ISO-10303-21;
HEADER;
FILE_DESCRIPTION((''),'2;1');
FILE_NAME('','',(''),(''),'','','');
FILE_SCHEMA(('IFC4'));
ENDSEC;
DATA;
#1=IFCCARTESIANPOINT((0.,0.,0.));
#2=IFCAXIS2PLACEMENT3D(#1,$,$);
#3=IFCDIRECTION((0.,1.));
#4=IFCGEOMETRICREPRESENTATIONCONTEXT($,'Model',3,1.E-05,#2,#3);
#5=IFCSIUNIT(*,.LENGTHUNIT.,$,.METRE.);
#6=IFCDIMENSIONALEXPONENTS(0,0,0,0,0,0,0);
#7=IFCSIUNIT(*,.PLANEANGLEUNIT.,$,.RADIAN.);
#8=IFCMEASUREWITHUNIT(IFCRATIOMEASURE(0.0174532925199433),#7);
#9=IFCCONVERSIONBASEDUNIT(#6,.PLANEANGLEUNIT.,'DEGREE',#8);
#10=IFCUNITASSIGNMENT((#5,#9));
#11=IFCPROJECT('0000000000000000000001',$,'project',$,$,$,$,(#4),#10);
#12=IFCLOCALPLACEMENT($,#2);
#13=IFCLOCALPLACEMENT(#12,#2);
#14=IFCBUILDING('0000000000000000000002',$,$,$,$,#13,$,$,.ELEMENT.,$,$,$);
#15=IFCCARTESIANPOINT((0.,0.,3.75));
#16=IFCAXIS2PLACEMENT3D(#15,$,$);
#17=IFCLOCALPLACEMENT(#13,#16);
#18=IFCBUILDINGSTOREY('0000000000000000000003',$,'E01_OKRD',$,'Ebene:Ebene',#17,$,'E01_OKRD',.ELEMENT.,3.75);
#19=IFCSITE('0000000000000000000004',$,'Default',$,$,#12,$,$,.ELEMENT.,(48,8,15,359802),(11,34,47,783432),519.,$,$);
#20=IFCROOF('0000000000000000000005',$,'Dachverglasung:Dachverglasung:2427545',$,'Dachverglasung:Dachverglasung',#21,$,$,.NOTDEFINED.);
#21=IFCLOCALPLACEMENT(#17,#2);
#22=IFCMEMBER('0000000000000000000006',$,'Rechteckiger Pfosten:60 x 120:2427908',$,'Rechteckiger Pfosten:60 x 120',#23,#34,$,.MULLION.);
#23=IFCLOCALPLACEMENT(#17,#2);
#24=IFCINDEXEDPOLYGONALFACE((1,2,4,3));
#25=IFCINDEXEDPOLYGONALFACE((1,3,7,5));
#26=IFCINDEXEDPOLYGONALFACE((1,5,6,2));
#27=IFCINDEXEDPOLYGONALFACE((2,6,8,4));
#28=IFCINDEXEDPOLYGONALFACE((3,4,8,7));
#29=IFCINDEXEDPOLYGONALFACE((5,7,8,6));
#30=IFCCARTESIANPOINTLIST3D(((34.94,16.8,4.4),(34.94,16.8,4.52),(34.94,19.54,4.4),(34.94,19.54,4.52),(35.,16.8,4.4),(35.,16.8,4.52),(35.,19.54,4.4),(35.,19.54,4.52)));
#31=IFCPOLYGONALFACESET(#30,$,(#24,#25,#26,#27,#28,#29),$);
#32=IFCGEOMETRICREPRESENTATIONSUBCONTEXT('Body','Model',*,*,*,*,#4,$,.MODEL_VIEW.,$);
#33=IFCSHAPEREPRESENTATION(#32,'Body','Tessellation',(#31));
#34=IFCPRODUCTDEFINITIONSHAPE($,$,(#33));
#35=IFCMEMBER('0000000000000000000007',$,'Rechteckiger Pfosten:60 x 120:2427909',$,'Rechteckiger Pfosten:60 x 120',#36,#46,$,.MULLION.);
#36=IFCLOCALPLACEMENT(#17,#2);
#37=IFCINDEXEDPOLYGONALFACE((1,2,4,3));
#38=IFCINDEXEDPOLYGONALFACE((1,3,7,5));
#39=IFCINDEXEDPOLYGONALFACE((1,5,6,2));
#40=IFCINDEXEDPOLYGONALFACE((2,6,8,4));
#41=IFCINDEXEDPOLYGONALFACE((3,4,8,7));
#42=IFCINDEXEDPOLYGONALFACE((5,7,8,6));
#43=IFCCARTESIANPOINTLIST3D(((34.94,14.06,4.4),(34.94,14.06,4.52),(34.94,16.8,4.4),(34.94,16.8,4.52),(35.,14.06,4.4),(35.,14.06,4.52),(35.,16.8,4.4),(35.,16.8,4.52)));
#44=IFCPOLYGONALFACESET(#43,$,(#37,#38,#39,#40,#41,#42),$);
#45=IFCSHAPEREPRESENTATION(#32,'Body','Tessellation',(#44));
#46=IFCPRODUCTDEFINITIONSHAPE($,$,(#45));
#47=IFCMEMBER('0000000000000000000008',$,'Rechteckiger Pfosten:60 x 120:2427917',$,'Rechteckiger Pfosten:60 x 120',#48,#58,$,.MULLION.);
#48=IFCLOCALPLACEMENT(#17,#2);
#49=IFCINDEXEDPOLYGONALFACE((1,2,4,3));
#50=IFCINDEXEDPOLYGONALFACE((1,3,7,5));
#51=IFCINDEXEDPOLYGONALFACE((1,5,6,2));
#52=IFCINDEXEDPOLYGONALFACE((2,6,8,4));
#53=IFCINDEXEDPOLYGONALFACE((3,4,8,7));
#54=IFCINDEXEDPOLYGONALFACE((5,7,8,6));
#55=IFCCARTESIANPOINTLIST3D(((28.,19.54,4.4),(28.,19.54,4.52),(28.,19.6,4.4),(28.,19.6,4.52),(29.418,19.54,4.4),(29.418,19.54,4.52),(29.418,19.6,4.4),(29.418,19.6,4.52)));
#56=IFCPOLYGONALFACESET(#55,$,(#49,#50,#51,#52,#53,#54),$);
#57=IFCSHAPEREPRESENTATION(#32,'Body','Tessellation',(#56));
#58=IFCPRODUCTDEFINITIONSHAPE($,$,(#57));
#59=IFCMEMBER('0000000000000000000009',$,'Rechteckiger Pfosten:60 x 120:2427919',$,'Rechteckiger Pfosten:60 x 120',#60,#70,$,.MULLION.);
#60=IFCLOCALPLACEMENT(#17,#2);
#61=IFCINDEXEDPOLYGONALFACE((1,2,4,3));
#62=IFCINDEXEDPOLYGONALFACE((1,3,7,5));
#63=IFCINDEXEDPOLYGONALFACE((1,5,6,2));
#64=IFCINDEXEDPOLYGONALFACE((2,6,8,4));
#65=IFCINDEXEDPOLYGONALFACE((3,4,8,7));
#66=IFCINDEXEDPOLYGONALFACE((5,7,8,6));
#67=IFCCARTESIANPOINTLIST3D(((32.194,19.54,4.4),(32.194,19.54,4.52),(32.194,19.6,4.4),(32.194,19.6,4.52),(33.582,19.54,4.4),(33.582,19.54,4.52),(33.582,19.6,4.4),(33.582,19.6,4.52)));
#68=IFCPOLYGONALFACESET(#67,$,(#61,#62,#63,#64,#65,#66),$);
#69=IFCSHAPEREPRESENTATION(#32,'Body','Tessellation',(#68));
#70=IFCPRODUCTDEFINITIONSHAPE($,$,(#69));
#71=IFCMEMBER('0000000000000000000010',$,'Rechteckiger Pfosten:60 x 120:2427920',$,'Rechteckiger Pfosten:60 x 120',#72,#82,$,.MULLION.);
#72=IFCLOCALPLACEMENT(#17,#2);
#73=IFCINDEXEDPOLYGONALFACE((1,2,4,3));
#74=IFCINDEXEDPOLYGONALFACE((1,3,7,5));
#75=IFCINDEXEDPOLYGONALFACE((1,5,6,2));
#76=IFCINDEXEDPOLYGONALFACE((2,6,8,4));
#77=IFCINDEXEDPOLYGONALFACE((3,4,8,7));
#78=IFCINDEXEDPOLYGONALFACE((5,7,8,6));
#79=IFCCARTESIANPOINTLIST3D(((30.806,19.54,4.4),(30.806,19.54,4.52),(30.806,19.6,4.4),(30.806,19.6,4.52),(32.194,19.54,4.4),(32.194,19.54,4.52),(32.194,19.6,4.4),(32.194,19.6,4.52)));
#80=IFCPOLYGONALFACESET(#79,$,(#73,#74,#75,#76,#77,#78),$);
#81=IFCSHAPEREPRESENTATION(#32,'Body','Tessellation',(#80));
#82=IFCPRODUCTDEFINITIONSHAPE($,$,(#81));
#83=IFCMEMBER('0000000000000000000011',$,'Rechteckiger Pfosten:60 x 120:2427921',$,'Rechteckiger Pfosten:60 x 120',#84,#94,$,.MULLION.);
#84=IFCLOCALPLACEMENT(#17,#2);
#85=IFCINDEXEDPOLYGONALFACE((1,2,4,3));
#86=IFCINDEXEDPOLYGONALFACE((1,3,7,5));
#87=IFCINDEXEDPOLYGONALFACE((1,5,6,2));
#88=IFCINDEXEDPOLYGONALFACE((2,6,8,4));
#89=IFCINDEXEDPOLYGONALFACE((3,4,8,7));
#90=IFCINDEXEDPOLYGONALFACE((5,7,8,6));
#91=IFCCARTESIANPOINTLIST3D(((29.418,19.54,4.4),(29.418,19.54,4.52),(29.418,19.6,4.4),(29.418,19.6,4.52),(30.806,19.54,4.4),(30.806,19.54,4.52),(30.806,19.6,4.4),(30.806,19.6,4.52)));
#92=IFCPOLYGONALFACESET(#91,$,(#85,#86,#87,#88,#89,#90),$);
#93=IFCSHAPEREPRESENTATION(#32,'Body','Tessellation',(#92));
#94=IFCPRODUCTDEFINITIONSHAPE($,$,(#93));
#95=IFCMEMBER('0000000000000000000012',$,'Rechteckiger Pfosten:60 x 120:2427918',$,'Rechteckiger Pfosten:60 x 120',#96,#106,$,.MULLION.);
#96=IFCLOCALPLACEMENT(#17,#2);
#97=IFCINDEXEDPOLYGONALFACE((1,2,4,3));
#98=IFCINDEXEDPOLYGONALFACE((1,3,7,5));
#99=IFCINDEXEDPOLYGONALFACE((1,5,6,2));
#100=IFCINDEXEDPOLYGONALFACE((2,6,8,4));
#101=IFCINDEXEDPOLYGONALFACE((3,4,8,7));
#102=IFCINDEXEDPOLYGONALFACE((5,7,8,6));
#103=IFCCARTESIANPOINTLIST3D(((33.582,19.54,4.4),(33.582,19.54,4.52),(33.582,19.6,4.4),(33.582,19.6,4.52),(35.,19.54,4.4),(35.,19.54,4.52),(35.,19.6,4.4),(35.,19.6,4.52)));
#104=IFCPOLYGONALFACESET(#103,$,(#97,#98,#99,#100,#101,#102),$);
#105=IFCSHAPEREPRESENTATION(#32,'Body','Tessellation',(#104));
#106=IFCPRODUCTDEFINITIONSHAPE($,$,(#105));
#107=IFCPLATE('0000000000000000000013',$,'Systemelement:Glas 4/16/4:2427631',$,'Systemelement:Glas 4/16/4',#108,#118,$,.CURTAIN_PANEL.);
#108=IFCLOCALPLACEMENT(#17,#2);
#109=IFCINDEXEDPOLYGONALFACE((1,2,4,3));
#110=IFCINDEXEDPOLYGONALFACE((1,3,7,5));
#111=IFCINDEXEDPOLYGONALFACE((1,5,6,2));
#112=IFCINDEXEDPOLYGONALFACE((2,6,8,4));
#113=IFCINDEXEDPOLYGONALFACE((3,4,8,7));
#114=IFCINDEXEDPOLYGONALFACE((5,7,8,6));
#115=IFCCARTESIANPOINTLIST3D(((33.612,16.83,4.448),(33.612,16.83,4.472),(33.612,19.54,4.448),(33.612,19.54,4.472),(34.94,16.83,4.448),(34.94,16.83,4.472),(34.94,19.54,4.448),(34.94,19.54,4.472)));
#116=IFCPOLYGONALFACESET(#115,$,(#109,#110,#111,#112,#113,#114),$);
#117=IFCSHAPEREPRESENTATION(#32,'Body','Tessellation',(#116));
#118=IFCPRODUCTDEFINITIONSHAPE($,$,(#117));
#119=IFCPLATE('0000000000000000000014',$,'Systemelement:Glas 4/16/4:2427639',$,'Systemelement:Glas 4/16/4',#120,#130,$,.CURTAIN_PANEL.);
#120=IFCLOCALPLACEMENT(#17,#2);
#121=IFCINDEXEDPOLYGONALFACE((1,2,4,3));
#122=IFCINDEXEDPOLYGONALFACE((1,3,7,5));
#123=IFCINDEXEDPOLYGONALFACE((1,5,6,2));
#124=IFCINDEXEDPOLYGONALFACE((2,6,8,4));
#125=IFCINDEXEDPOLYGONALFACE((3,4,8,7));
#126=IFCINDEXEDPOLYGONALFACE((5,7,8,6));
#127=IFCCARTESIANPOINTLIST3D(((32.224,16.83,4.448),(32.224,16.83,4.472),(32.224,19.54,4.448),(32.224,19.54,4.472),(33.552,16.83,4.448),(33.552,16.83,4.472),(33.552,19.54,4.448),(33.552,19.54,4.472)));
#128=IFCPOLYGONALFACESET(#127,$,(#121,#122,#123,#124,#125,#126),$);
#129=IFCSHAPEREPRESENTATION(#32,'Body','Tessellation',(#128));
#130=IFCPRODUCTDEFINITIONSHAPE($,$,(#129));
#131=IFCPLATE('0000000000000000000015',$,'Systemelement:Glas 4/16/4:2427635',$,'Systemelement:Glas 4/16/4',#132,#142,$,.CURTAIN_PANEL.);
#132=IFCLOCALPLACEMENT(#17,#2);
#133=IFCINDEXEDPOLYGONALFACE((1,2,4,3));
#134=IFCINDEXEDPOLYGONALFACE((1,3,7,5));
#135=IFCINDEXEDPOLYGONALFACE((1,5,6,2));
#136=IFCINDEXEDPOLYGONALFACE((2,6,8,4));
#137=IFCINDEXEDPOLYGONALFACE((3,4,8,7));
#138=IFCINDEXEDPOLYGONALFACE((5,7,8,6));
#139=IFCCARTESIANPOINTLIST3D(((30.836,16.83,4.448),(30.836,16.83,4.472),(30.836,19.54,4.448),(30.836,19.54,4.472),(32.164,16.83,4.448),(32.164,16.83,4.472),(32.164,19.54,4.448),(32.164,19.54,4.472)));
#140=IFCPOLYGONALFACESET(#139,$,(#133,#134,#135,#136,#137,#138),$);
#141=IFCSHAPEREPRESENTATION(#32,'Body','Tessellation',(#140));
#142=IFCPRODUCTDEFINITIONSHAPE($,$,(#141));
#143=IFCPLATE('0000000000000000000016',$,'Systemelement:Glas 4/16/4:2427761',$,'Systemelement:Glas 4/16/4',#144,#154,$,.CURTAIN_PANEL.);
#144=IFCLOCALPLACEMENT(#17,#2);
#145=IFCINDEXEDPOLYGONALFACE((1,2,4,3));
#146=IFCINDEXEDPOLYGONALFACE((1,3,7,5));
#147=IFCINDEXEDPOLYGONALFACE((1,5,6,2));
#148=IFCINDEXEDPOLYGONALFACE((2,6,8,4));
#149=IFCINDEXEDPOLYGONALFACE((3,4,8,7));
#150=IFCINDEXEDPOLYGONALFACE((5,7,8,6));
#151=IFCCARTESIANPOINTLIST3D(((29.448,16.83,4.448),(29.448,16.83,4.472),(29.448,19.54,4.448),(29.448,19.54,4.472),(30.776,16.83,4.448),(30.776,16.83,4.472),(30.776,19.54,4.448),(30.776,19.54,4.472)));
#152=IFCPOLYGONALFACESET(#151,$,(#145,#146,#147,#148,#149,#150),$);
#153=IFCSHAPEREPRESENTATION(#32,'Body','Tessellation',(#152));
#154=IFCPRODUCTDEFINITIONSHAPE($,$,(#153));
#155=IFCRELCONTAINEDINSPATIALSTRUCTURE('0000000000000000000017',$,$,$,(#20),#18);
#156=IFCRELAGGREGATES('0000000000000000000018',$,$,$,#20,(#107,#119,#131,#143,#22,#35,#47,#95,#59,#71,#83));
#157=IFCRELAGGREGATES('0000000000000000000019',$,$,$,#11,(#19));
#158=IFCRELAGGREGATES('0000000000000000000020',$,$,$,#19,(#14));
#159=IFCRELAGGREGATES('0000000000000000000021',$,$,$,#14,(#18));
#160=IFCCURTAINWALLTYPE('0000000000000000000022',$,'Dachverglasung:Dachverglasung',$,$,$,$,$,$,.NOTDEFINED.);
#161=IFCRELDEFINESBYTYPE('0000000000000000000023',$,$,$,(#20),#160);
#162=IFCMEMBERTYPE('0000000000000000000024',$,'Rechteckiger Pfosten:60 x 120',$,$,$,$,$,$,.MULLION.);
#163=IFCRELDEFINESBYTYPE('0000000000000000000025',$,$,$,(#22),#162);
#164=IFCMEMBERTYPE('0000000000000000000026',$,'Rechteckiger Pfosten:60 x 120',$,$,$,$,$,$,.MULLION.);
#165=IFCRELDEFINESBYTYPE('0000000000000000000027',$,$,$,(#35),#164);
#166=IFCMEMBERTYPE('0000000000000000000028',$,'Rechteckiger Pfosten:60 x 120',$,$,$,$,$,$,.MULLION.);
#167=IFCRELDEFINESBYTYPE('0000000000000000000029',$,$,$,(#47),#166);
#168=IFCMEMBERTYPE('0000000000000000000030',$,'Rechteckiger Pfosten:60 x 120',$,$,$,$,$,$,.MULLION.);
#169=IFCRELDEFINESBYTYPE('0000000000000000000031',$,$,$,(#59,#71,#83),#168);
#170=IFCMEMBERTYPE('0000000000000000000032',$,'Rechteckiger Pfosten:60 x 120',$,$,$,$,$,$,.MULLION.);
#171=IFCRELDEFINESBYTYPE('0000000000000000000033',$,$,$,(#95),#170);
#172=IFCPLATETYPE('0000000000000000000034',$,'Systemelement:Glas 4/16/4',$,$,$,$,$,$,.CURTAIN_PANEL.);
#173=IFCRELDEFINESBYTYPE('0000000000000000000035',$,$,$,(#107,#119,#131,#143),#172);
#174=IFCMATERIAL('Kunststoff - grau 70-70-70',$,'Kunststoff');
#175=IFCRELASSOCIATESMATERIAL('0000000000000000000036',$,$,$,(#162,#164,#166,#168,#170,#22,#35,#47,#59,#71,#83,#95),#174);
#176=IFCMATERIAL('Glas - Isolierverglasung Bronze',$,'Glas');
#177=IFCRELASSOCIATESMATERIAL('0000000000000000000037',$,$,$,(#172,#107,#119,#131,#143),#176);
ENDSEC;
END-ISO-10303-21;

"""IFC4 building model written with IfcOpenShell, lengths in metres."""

from ifc_helpers import new_model, entity, si_unit, converted_unit, direction, frame, frame_2d, origin, origin_2d_with_axis, place, context, subcontext, project, spatial, rectangle, extrude, shape, source, transform, mapped, material, material_profile, profile_set, profile_usage, type_object, type_shapes, element, aggregate, save


model = new_model("IFC4")

# Units and contexts
model_context = context("Model", 3, precision=1e-05, world=origin(), true_north=direction((0.0, 1.0)))
body_context = subcontext(model_context, "Body", "Model", "MODEL_VIEW")
footprint_context = subcontext(model_context, "FootPrint", "Model", "MODEL_VIEW")
ifc_project = project(units=[si_unit("LENGTHUNIT", "METRE"), converted_unit("PLANEANGLEUNIT", "DEGREE", entity("IfcRatioMeasure", 0.0174532925199433), si_unit("PLANEANGLEUNIT", "RADIAN"), dimensions=[0, 0, 0, 0, 0, 0, 0])], contexts=[model_context])

# Site, building, storey
site_placement = place(None, frame((0.0, 0.0, 0.0)))
site = spatial("IfcSite", under=ifc_project, at=site_placement, Name="Default", CompositionType="ELEMENT", RefLatitude=(48, 8, 15, 359802), RefLongitude=(11, 34, 47, 783432), RefElevation=519.0)
building_placement = place(site_placement, origin())
building = spatial("IfcBuilding", under=site, at=building_placement, CompositionType="ELEMENT")
storey_placement = place(building_placement, frame((0.0, 0.0, 3.75)))
storey = spatial("IfcBuildingStorey", under=building, at=storey_placement, Name="E01_OKRD", ObjectType="Ebene:Ebene", LongName="E01_OKRD", CompositionType="ELEMENT", Elevation=3.75)

# Roof, members, plates
curtain_wall_type = type_object("IfcCurtainWallType", Name="Dachverglasung:Dachverglasung", PredefinedType="NOTDEFINED")
roof_placement = place(storey_placement, frame((0.0, 0.0, -3.75)))
roof = element("IfcRoof", 1, at=roof_placement, inside=storey, type_object=curtain_wall_type, Name="Dachverglasung:Dachverglasung:2427545", ObjectType="Dachverglasung:Dachverglasung", PredefinedType="NOTDEFINED")
ifc_material_1 = material(Name="Kunststoff - grau 70-70-70", Category="Kunststoff")
ifc_material_profile_1 = material_profile(ifc_material_1, rectangle(XDim=0.06, YDim=0.12, at=frame_2d((0.0, 0.0), x_axis=(1.0, 0.0))), Name="60 x 120")
ifc_profile_set_1 = profile_set([ifc_material_profile_1], Name="60 x 120")
ifc_profile_usage_1 = profile_usage(ifc_profile_set_1)
member_type_1 = type_object("IfcMemberType", Name="Rechteckiger Pfosten:60 x 120", PredefinedType="MULLION", material=ifc_profile_set_1)
shared_shape_1 = source(origin(), body_context, "Body", "SweptSolid", [
    extrude(rectangle(XDim=0.06, YDim=0.12, at=origin_2d_with_axis()), frame((-0.03, 0.0, -2.74), z_axis=(0.0, 0.0, 1.0), x_axis=(-1.0, 0.0, 0.0)), (0.0, 0.0, 1.0), 2.74),
])
type_shapes(member_type_1, [shared_shape_1])
member_1_placement = place(storey_placement, frame((35.0, 19.54, 4.46), z_axis=(0.0, 1.0, 0.0), x_axis=(1.0, 0.0, 0.0)))
member_1 = element("IfcMember", 2, at=member_1_placement, type_object=member_type_1, material=ifc_profile_usage_1, Name="Rechteckiger Pfosten:60 x 120:2427908", ObjectType="Rechteckiger Pfosten:60 x 120", PredefinedType="MULLION", context=body_context, shape_type="MappedRepresentation", body=[
    mapped(shared_shape_1, transform((0.0, 0.0, 0.0), scale=1.0)),
])
ifc_profile_usage_2 = profile_usage(ifc_profile_set_1)
member_type_2 = type_object("IfcMemberType", Name="Rechteckiger Pfosten:60 x 120", PredefinedType="MULLION", material=ifc_profile_set_1)
shared_shape_2 = source(origin(), body_context, "Body", "SweptSolid", [
    extrude(rectangle(XDim=0.06, YDim=0.12, at=origin_2d_with_axis()), frame((-0.03, 0.0, -2.74), z_axis=(0.0, 0.0, 1.0), x_axis=(-1.0, 0.0, 0.0)), (0.0, 0.0, 1.0), 2.74),
])
type_shapes(member_type_2, [shared_shape_2])
member_2_placement = place(storey_placement, frame((35.0, 16.8, 4.46), z_axis=(0.0, 1.0, 0.0), x_axis=(1.0, 0.0, 0.0)))
member_2 = element("IfcMember", 3, at=member_2_placement, type_object=member_type_2, material=ifc_profile_usage_2, Name="Rechteckiger Pfosten:60 x 120:2427909", ObjectType="Rechteckiger Pfosten:60 x 120", PredefinedType="MULLION", context=body_context, shape_type="MappedRepresentation", body=[
    mapped(shared_shape_2, transform((0.0, 0.0, 0.0), scale=1.0)),
])
ifc_profile_usage_3 = profile_usage(ifc_profile_set_1)
member_type_3 = type_object("IfcMemberType", Name="Rechteckiger Pfosten:60 x 120", PredefinedType="MULLION", material=ifc_profile_set_1)
shared_shape_3 = source(origin(), body_context, "Body", "SweptSolid", [
    extrude(rectangle(XDim=0.06, YDim=0.12, at=origin_2d_with_axis()), frame((-0.03, 0.0, -1.418), z_axis=(0.0, 0.0, 1.0), x_axis=(-1.0, 0.0, 0.0)), (0.0, 0.0, 1.0), 1.418),
])
type_shapes(member_type_3, [shared_shape_3])
member_3_placement = place(storey_placement, frame((28.0, 19.6, 4.46), z_axis=(-1.0, 0.0, 0.0), x_axis=(0.0, 1.0, 0.0)))
member_3 = element("IfcMember", 4, at=member_3_placement, type_object=member_type_3, material=ifc_profile_usage_3, Name="Rechteckiger Pfosten:60 x 120:2427917", ObjectType="Rechteckiger Pfosten:60 x 120", PredefinedType="MULLION", context=body_context, shape_type="MappedRepresentation", body=[
    mapped(shared_shape_3, transform((0.0, 0.0, 0.0), scale=1.0)),
])
ifc_profile_usage_4 = profile_usage(ifc_profile_set_1)
member_type_4 = type_object("IfcMemberType", Name="Rechteckiger Pfosten:60 x 120", PredefinedType="MULLION", material=ifc_profile_set_1)
shared_shape_4 = source(origin(), body_context, "Body", "SweptSolid", [
    extrude(rectangle(XDim=0.06, YDim=0.12, at=origin_2d_with_axis()), frame((-0.03, 0.0, -1.388), z_axis=(0.0, 0.0, 1.0), x_axis=(-1.0, 0.0, 0.0)), (0.0, 0.0, 1.0), 1.388),
])
type_shapes(member_type_4, [shared_shape_4])
member_4_placement = place(storey_placement, frame((32.194, 19.6, 4.46), z_axis=(-1.0, 0.0, 0.0), x_axis=(0.0, 1.0, 0.0)))
member_4 = element("IfcMember", 5, at=member_4_placement, type_object=member_type_4, material=ifc_profile_usage_4, Name="Rechteckiger Pfosten:60 x 120:2427919", ObjectType="Rechteckiger Pfosten:60 x 120", PredefinedType="MULLION", context=body_context, shape_type="MappedRepresentation", body=[
    mapped(shared_shape_4, transform((0.0, 0.0, 0.0), scale=1.0)),
])
ifc_profile_usage_5 = profile_usage(ifc_profile_set_1)
member_5_placement = place(storey_placement, frame((30.806, 19.6, 4.46), z_axis=(-1.0, 0.0, 0.0), x_axis=(0.0, 1.0, 0.0)))
member_5 = element("IfcMember", 6, at=member_5_placement, type_object=member_type_4, material=ifc_profile_usage_5, Name="Rechteckiger Pfosten:60 x 120:2427920", ObjectType="Rechteckiger Pfosten:60 x 120", PredefinedType="MULLION", context=body_context, shape_type="MappedRepresentation", body=[
    mapped(shared_shape_4, transform((0.0, 0.0, 0.0), scale=1.0)),
])
ifc_profile_usage_6 = profile_usage(ifc_profile_set_1)
member_6_placement = place(storey_placement, frame((29.418, 19.6, 4.46), z_axis=(-1.0, 0.0, 0.0), x_axis=(0.0, 1.0, 0.0)))
member_6 = element("IfcMember", 7, at=member_6_placement, type_object=member_type_4, material=ifc_profile_usage_6, Name="Rechteckiger Pfosten:60 x 120:2427921", ObjectType="Rechteckiger Pfosten:60 x 120", PredefinedType="MULLION", context=body_context, shape_type="MappedRepresentation", body=[
    mapped(shared_shape_4, transform((0.0, 0.0, 0.0), scale=1.0)),
])
ifc_profile_usage_7 = profile_usage(ifc_profile_set_1)
member_type_5 = type_object("IfcMemberType", Name="Rechteckiger Pfosten:60 x 120", PredefinedType="MULLION", material=ifc_profile_set_1)
shared_shape_5 = source(origin(), body_context, "Body", "SweptSolid", [
    extrude(rectangle(XDim=0.06, YDim=0.12, at=origin_2d_with_axis()), frame((-0.03, 0.0, -1.418), z_axis=(0.0, 0.0, 1.0), x_axis=(-1.0, 0.0, 0.0)), (0.0, 0.0, 1.0), 1.418),
])
type_shapes(member_type_5, [shared_shape_5])
member_7_placement = place(storey_placement, frame((33.582, 19.6, 4.46), z_axis=(-1.0, 0.0, 0.0), x_axis=(0.0, 1.0, 0.0)))
member_7 = element("IfcMember", 8, at=member_7_placement, type_object=member_type_5, material=ifc_profile_usage_7, Name="Rechteckiger Pfosten:60 x 120:2427918", ObjectType="Rechteckiger Pfosten:60 x 120", PredefinedType="MULLION", context=body_context, shape_type="MappedRepresentation", body=[
    mapped(shared_shape_5, transform((0.0, 0.0, 0.0), scale=1.0)),
])
ifc_material_2 = material(Name="Glas - Isolierverglasung Bronze", Category="Glas")
plate_type = type_object("IfcPlateType", Name="Systemelement:Glas 4/16/4", PredefinedType="CURTAIN_PANEL", material=ifc_material_2)
shared_shape_6 = source(origin(), body_context, "Body", "SweptSolid", [
    extrude(rectangle(XDim=0.024, YDim=2.71, at=origin_2d_with_axis()), frame((0.0, 0.0, 0.0), z_axis=(0.0, 0.0, 1.0), x_axis=(0.0, 1.0, 0.0)), (0.0, 0.0, 1.0), 1.328),
])
cartesian_point = entity("IfcCartesianPoint", [1.355, -0.012])
shared_shape_7 = source(origin(), footprint_context, "FootPrint", "Curve2D", [
    entity("IfcPolyline", [cartesian_point, entity("IfcCartesianPoint", [1.355, 0.012]), entity("IfcCartesianPoint", [-1.355, 0.012]), entity("IfcCartesianPoint", [-1.355, -0.012]), cartesian_point]),
])
type_shapes(plate_type, [shared_shape_6, shared_shape_7])
plate_1_placement = place(roof_placement, frame((34.94, 18.185, 8.21), z_axis=(-1.0, 0.0, 0.0), x_axis=(0.0, 1.0, 0.0)))
plate_1 = element("IfcPlate", 9, at=plate_1_placement, type_object=plate_type, material=ifc_material_2, Name="Systemelement:Glas 4/16/4:2427631", ObjectType="Systemelement:Glas 4/16/4", PredefinedType="CURTAIN_PANEL", shapes=[
    shape(body_context, "Body", "MappedRepresentation", [mapped(shared_shape_6, transform((0.0, 0.0, 0.0), scale=1.0))]),
    shape(body_context, "Body", "MappedRepresentation", [mapped(shared_shape_7, transform((0.0, 0.0, 0.0), scale=1.0))]),
])
plate_2_placement = place(roof_placement, frame((33.552, 18.185, 8.21), z_axis=(-1.0, 0.0, 0.0), x_axis=(0.0, 1.0, 0.0)))
plate_2 = element("IfcPlate", 10, at=plate_2_placement, type_object=plate_type, material=ifc_material_2, Name="Systemelement:Glas 4/16/4:2427639", ObjectType="Systemelement:Glas 4/16/4", PredefinedType="CURTAIN_PANEL", shapes=[
    shape(body_context, "Body", "MappedRepresentation", [mapped(shared_shape_6, transform((0.0, 0.0, 0.0), scale=1.0))]),
    shape(body_context, "Body", "MappedRepresentation", [mapped(shared_shape_7, transform((0.0, 0.0, 0.0), scale=1.0))]),
])
plate_3_placement = place(roof_placement, frame((32.164, 18.185, 8.21), z_axis=(-1.0, 0.0, 0.0), x_axis=(0.0, 1.0, 0.0)))
plate_3 = element("IfcPlate", 11, at=plate_3_placement, type_object=plate_type, material=ifc_material_2, Name="Systemelement:Glas 4/16/4:2427635", ObjectType="Systemelement:Glas 4/16/4", PredefinedType="CURTAIN_PANEL", shapes=[
    shape(body_context, "Body", "MappedRepresentation", [mapped(shared_shape_6, transform((0.0, 0.0, 0.0), scale=1.0))]),
    shape(body_context, "Body", "MappedRepresentation", [mapped(shared_shape_7, transform((0.0, 0.0, 0.0), scale=1.0))]),
])
plate_4_placement = place(roof_placement, frame((30.776, 18.185, 8.21), z_axis=(-1.0, 0.0, 0.0), x_axis=(0.0, 1.0, 0.0)))
plate_4 = element("IfcPlate", 12, at=plate_4_placement, type_object=plate_type, material=ifc_material_2, Name="Systemelement:Glas 4/16/4:2427761", ObjectType="Systemelement:Glas 4/16/4", PredefinedType="CURTAIN_PANEL", shapes=[
    shape(body_context, "Body", "MappedRepresentation", [mapped(shared_shape_6, transform((0.0, 0.0, 0.0), scale=1.0))]),
    shape(body_context, "Body", "MappedRepresentation", [mapped(shared_shape_7, transform((0.0, 0.0, 0.0), scale=1.0))]),
])
aggregate(roof, [plate_1, plate_2, plate_3, plate_4, member_1, member_2, member_3, member_7, member_4, member_5, member_6])

save(model, "model.ifc")
